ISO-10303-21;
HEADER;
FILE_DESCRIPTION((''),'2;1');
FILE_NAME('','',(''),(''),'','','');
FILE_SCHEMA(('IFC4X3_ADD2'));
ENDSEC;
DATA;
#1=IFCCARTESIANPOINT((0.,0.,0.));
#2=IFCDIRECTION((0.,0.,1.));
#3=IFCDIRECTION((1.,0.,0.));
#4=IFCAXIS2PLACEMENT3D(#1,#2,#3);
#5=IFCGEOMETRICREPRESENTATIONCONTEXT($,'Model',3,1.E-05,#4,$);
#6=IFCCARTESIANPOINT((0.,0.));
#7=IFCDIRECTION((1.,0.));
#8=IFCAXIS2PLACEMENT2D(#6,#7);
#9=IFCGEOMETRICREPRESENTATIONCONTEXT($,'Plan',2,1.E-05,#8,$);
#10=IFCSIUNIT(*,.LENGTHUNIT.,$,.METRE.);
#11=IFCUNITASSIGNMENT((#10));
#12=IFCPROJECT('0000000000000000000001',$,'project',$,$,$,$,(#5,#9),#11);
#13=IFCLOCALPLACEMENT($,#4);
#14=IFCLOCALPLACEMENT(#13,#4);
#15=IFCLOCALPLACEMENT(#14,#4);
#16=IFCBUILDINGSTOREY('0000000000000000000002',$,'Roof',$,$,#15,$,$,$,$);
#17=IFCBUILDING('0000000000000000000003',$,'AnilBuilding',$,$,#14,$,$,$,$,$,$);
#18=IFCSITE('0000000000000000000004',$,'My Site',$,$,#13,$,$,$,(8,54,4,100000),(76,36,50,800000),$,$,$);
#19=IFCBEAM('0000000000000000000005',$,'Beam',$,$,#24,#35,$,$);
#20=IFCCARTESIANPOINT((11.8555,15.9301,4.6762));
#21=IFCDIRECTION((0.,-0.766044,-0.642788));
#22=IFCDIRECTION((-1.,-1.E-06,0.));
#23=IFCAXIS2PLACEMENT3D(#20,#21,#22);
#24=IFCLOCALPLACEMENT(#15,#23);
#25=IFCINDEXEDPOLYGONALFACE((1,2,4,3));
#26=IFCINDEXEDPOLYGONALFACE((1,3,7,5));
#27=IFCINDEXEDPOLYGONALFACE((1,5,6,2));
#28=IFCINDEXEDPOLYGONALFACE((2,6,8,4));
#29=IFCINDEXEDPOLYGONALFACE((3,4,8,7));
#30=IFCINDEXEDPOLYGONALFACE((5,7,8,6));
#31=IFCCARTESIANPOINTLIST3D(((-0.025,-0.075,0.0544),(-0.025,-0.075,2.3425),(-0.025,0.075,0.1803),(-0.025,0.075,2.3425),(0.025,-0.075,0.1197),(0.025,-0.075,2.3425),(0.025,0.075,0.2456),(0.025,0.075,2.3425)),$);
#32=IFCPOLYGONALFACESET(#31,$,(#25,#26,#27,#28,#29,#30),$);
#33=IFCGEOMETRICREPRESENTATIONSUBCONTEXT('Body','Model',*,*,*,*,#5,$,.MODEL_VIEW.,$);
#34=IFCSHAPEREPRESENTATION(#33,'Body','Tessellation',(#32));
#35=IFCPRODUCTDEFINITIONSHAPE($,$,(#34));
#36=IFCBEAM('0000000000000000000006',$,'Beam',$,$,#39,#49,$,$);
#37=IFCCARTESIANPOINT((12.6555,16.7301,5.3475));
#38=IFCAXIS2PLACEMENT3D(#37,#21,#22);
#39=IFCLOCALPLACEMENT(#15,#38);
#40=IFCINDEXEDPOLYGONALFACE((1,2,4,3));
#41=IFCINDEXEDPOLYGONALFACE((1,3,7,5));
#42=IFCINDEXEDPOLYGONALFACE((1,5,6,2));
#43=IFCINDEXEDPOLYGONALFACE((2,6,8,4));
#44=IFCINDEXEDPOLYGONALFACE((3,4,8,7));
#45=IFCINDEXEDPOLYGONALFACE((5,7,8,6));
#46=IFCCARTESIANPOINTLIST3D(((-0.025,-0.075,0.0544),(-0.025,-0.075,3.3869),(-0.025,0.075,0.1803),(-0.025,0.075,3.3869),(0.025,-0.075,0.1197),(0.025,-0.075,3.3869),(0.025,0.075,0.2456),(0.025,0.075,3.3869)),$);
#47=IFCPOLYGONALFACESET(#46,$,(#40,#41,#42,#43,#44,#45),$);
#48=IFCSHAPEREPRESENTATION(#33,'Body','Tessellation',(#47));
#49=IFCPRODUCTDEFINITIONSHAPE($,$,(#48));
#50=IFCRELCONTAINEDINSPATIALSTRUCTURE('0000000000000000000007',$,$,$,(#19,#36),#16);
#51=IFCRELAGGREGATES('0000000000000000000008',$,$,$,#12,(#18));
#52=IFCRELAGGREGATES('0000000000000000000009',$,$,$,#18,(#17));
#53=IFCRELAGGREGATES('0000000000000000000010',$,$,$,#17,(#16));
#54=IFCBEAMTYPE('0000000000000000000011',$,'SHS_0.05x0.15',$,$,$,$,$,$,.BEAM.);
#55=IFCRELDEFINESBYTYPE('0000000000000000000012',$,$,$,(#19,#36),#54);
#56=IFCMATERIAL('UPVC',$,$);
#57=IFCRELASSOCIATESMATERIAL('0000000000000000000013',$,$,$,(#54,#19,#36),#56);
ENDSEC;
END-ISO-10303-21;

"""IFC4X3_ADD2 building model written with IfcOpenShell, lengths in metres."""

from ifc_helpers import new_model, si_unit, frame, origin_with_axes, origin_2d_with_axis, place, context, subcontext, project, spatial, indexed_curve, outline, extrude, clip, halfspace, material, material_profile, profile_set, profile_usage, type_object, element, save


model = new_model("IFC4X3_ADD2")

# Units and contexts
model_context = context("Model", 3, precision=1e-05, world=origin_with_axes())
plan_context = context("Plan", 2, precision=1e-05, world=origin_2d_with_axis())
body_context_1 = subcontext(model_context, "Body", "Model", "MODEL_VIEW")
ifc_project = project(units=[si_unit("LENGTHUNIT", "METRE")], contexts=[model_context, plan_context])

# Site, building, storey
site_placement = place(None, origin_with_axes())
site = spatial("IfcSite", under=ifc_project, at=site_placement, Name="My Site", RefLatitude=(8, 54, 4, 100000), RefLongitude=(76, 36, 50, 800000))
building_placement = place(site_placement, origin_with_axes())
building = spatial("IfcBuilding", under=site, at=building_placement, Name="AnilBuilding")
storey_placement = place(building_placement, origin_with_axes())
storey = spatial("IfcBuildingStorey", under=building, at=storey_placement, Name="Roof")

# Shared definitions
ifc_material_1 = material(Name="UPVC")

# Beams
ifc_material_profile_1 = material_profile(ifc_material_1, outline(indexed_curve([(-0.025, 0.075), (0.025, 0.075), (0.025, -0.075), (-0.025, -0.075), (-0.025, 0.075)])))
ifc_profile_set_1 = profile_set([ifc_material_profile_1])
beam_type = type_object("IfcBeamType", Name="SHS_0.05x0.15", PredefinedType="BEAM", material=ifc_profile_set_1)
ifc_profile_usage_1 = profile_usage(ifc_profile_set_1, cardinal=5)
beam_1_placement = place(storey_placement, frame((11.8555, 15.9301, 4.6762), z_axis=(0.0, -0.766044, -0.642788), x_axis=(-1.0, -0.000001, 0.0)))
element("IfcBeam", 1, at=beam_1_placement, inside=storey, type_object=beam_type, material=ifc_profile_usage_1, Name="Beam", context=body_context_1, shape_type="Clipping", body=[
    clip(extrude(outline(indexed_curve([(-0.025, 0.075), (0.025, 0.075), (0.025, -0.075), (-0.025, -0.075), (-0.025, 0.075)])), origin_with_axes(), (0.0, 0.0, 1.0), 2.3425), halfspace(frame((-2.191, 0.0439, -2.6733), z_axis=(0.707107, 0.454519, -0.541675), x_axis=(0.540716, -0.841205, 0.0)), False)),
])
ifc_profile_usage_2 = profile_usage(ifc_profile_set_1, cardinal=5)
beam_2_placement = place(storey_placement, frame((12.6555, 16.7301, 5.3475), z_axis=(0.0, -0.766044, -0.642788), x_axis=(-1.0, -0.000001, 0.0)))
element("IfcBeam", 2, at=beam_2_placement, inside=storey, type_object=beam_type, material=ifc_profile_usage_2, Name="Beam", context=body_context_1, shape_type="Clipping", body=[
    clip(extrude(outline(indexed_curve([(-0.025, 0.075), (0.025, 0.075), (0.025, -0.075), (-0.025, -0.075), (-0.025, 0.075)])), origin_with_axes(), (0.0, 0.0, 1.0), 3.3869), halfspace(frame((-1.391, 0.0439, -1.629), z_axis=(0.707107, 0.454519, -0.541675), x_axis=(0.540716, -0.841205, 0.0)), False)),
])

save(model, "model.ifc")
